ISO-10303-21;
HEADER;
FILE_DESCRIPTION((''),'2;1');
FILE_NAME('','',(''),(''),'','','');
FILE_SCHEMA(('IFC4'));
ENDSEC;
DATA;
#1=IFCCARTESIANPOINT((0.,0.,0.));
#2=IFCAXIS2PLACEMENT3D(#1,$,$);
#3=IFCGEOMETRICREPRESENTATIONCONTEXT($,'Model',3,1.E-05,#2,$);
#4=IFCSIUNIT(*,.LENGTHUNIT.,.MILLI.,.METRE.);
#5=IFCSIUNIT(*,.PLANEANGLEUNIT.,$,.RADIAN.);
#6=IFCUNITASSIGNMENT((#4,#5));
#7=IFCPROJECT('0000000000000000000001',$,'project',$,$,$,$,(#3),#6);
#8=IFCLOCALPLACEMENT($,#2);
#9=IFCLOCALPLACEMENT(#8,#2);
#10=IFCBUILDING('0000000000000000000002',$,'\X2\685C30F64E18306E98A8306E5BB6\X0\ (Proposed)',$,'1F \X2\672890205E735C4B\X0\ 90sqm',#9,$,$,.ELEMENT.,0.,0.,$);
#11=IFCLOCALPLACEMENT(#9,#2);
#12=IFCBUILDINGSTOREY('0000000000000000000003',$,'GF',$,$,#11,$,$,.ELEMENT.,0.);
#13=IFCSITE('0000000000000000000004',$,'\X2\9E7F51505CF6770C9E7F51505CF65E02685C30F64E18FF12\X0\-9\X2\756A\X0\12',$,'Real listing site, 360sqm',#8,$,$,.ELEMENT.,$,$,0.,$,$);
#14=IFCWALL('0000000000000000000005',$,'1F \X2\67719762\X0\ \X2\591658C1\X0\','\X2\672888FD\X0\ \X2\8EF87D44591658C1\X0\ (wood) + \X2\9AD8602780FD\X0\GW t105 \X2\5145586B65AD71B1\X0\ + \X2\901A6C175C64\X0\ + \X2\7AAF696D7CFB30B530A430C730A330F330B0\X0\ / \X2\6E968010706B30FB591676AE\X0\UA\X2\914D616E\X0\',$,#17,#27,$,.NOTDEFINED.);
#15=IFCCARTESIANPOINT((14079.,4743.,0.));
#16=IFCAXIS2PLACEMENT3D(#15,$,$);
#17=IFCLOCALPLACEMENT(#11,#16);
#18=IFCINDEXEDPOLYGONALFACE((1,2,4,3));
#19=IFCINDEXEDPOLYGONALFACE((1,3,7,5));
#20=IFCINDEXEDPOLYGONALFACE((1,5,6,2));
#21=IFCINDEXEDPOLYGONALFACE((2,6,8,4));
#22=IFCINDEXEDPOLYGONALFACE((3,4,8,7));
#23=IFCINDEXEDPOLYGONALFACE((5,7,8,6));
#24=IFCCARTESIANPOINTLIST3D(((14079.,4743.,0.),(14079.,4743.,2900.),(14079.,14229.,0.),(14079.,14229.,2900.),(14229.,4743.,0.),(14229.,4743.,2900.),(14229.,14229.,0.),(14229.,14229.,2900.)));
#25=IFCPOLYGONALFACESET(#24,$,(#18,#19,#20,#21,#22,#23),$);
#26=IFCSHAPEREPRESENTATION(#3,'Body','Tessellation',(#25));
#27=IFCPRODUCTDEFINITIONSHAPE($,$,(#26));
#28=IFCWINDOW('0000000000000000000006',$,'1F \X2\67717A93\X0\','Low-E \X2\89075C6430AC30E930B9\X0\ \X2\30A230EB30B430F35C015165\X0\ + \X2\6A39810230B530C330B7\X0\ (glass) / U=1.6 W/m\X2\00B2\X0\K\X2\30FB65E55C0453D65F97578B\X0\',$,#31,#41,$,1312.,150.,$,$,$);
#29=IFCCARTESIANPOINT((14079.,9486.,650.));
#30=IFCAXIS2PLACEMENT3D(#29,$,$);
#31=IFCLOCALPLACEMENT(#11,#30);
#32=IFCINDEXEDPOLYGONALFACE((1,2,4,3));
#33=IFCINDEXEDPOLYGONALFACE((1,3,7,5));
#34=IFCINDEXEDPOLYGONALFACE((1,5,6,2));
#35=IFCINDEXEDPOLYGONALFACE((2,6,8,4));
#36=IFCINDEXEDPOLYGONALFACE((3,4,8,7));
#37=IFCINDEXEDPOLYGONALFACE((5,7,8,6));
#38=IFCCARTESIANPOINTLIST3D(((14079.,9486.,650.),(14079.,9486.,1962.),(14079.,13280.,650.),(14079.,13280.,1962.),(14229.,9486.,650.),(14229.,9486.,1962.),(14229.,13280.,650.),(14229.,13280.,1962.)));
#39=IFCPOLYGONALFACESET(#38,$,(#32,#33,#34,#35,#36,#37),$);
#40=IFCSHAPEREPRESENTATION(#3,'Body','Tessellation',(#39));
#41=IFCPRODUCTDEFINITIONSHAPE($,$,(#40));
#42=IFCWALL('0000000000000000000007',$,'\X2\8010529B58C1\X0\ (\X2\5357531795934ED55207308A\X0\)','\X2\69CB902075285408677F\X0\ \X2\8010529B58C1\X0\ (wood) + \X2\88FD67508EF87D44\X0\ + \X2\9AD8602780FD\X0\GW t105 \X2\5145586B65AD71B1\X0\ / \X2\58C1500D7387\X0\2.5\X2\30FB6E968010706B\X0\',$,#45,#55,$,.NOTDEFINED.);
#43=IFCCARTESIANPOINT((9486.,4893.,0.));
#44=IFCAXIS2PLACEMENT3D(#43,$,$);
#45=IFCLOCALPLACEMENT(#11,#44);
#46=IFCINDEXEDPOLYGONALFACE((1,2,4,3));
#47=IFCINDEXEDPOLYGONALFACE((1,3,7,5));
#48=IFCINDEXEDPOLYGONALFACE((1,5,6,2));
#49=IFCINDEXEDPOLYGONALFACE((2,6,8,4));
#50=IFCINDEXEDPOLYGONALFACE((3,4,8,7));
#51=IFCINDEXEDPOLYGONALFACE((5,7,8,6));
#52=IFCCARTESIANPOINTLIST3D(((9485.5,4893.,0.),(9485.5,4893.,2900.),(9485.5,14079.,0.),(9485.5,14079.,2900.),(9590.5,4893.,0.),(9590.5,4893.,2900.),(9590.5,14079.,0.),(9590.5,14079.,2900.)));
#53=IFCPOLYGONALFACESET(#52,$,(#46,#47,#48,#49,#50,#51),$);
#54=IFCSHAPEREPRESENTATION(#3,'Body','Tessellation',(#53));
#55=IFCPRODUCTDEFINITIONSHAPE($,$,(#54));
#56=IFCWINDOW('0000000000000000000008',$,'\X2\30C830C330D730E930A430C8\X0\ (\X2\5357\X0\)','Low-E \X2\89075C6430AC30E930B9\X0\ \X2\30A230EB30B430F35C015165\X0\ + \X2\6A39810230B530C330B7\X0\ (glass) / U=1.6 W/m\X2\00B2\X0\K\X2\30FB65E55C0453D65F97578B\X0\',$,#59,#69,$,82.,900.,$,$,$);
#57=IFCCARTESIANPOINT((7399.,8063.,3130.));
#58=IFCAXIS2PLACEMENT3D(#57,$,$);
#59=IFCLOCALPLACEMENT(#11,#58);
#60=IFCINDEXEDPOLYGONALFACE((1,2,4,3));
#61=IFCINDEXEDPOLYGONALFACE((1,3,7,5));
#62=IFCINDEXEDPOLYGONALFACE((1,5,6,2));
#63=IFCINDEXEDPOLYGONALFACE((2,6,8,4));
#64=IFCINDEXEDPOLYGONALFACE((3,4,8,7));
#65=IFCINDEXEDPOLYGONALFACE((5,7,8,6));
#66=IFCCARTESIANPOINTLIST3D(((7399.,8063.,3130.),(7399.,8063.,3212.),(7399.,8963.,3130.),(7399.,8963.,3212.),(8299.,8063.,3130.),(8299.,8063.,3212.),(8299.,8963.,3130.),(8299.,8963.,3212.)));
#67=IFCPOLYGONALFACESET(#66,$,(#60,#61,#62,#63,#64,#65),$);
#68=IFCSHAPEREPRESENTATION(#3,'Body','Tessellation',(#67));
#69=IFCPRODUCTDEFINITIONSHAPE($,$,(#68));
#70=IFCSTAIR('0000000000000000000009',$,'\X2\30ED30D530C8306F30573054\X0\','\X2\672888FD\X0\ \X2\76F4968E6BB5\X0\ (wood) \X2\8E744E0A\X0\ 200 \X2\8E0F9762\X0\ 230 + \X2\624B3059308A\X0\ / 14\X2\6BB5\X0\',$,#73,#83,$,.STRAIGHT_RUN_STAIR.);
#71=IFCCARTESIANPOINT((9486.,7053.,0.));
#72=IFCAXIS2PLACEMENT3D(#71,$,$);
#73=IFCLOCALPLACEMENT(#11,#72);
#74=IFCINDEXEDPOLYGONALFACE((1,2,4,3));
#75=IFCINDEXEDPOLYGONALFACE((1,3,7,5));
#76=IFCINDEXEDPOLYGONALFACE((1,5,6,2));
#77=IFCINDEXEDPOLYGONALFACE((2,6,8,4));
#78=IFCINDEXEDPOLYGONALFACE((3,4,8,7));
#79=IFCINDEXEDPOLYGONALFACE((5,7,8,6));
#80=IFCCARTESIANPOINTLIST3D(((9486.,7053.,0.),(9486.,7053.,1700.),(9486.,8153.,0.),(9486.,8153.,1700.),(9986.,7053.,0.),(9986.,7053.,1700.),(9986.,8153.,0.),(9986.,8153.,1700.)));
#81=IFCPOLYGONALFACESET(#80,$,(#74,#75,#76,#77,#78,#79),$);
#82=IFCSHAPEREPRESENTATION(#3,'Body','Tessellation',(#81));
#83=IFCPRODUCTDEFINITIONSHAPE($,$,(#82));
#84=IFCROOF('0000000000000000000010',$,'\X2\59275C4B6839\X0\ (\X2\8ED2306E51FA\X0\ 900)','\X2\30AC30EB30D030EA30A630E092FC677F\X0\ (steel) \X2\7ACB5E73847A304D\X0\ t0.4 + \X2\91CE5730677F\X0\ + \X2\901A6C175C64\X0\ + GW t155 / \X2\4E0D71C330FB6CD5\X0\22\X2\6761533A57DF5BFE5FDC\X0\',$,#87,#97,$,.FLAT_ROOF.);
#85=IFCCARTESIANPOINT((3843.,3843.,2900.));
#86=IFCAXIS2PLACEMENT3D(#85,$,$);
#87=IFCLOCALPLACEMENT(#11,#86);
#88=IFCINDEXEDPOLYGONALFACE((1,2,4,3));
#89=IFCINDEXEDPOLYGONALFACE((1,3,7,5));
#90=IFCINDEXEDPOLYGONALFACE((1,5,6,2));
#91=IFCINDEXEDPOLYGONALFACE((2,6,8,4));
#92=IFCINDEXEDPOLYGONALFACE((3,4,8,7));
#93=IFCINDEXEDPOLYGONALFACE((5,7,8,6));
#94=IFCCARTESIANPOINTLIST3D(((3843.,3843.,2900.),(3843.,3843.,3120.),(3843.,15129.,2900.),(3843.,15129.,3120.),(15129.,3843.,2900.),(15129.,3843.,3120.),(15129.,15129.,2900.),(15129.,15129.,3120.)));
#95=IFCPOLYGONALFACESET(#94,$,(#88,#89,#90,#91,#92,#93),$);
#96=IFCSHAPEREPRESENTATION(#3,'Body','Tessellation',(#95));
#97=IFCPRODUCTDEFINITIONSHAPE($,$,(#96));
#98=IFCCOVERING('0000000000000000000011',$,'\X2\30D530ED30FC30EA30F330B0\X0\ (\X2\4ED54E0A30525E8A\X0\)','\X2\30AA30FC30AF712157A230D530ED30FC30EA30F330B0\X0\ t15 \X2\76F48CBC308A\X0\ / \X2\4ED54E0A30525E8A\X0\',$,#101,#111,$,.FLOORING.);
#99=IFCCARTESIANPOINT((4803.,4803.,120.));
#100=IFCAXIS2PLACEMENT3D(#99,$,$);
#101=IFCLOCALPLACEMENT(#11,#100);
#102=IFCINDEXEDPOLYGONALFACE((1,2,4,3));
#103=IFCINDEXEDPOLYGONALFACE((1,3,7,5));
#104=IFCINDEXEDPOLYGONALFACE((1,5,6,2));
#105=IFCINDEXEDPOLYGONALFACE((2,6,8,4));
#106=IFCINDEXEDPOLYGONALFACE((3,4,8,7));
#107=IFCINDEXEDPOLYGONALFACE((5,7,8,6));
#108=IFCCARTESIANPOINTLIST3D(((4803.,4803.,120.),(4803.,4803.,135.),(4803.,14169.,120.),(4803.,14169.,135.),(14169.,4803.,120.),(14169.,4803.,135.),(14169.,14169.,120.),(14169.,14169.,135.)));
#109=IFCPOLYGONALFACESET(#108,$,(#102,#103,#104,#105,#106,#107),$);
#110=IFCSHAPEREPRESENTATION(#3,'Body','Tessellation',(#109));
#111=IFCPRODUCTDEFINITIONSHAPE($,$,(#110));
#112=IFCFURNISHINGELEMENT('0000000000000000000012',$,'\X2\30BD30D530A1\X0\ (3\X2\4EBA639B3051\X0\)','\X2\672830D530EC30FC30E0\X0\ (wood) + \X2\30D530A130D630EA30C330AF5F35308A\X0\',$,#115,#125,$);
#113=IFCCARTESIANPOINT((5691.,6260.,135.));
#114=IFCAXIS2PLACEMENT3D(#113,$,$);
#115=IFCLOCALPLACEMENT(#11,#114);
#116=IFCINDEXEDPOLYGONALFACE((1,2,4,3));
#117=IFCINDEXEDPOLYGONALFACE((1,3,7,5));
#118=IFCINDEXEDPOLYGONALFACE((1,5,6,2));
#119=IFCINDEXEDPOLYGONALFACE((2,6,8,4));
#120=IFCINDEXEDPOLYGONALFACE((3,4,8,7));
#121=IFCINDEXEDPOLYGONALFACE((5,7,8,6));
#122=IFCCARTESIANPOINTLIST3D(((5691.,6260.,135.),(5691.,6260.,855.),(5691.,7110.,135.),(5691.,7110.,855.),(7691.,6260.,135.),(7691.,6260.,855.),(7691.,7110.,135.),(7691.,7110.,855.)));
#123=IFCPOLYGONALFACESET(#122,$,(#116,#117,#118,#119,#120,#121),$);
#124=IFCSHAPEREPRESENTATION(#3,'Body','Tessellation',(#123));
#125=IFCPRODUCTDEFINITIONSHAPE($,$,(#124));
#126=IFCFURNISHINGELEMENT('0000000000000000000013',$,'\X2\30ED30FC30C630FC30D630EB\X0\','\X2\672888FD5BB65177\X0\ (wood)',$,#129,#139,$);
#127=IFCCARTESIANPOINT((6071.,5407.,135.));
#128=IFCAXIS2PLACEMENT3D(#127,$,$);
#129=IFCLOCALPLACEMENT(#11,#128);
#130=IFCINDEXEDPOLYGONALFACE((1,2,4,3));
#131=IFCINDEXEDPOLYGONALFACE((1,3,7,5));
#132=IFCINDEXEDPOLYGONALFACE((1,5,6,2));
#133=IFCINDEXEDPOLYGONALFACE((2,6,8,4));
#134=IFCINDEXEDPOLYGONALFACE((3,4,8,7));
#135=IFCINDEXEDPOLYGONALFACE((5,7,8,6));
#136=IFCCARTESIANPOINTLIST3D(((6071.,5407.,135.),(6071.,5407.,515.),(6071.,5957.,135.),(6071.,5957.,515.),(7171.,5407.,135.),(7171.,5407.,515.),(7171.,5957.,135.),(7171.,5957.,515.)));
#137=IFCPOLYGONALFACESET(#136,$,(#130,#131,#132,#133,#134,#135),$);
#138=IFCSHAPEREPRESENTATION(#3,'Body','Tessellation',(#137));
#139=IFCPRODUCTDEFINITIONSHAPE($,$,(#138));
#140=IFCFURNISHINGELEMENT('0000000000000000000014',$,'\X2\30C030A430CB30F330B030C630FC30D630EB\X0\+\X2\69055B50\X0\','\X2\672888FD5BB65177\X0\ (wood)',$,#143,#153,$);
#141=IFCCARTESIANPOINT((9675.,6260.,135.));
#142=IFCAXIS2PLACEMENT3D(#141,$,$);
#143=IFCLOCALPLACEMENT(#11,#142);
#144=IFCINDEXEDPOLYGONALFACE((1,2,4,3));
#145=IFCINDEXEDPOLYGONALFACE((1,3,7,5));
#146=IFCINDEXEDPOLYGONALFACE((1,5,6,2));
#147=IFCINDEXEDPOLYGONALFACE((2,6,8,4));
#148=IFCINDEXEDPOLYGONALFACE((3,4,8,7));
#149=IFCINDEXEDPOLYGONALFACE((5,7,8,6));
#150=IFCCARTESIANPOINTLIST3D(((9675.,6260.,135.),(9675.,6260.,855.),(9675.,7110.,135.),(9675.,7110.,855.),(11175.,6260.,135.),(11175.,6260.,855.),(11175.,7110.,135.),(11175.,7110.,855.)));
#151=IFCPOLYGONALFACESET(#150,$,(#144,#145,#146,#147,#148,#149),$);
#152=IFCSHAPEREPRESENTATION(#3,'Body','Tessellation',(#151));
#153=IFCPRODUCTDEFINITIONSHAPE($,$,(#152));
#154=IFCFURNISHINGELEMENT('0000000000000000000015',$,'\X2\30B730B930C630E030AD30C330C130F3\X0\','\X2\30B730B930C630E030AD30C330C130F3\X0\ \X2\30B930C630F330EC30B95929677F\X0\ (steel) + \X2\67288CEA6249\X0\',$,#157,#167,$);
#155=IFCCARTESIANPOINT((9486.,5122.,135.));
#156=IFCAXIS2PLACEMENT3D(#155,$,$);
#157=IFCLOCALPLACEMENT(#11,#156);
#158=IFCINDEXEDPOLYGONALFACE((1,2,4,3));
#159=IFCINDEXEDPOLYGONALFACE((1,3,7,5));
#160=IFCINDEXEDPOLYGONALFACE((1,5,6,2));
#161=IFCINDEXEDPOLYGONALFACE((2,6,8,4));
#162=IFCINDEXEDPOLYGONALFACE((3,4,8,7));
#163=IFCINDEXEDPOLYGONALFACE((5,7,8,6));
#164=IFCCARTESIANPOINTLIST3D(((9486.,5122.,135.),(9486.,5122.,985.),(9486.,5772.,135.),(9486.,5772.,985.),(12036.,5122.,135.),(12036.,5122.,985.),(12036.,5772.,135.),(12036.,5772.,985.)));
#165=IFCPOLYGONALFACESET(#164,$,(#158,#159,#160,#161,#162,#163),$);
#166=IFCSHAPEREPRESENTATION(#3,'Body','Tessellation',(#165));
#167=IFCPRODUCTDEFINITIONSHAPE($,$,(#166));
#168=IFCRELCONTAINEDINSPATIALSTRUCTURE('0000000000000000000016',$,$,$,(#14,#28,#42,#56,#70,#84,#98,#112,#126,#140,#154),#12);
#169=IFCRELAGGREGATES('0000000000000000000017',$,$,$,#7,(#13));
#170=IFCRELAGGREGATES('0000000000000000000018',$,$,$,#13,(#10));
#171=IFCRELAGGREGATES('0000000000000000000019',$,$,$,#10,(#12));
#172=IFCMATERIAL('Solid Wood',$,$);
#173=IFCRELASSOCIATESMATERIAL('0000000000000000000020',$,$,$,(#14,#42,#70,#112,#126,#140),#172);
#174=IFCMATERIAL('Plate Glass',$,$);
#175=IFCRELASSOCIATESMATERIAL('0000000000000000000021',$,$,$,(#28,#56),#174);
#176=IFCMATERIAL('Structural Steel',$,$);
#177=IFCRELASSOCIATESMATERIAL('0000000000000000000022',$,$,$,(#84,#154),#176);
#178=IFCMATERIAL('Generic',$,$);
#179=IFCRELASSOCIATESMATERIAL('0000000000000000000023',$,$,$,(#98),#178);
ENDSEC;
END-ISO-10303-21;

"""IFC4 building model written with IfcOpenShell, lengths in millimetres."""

from ifc_helpers import new_model, si_unit, frame, frame_2d, origin, place, context, project, spatial, rectangle, extrude, material, element, fill, save


model = new_model("IFC4")

# Units and contexts
model_context = context("Model", 3, precision=1e-05, world=origin())
ifc_project = project(units=[si_unit("LENGTHUNIT", "METRE", prefix="MILLI"), si_unit("PLANEANGLEUNIT", "RADIAN")], contexts=[model_context])

# Site, building, storey
site_placement = place(None, origin())
site = spatial("IfcSite", under=ifc_project, at=site_placement, Name="鹿児島県鹿児島市桜ヶ丘２-9番12", ObjectType="Real listing site, 360sqm", CompositionType="ELEMENT", RefElevation=0.0)
building_placement = place(site_placement, origin())
building = spatial("IfcBuilding", under=site, at=building_placement, Name="桜ヶ丘の風の家 (Proposed)", ObjectType="1F 木造平屋 90sqm", CompositionType="ELEMENT", ElevationOfRefHeight=0.0, ElevationOfTerrain=0.0)
storey_placement = place(building_placement, origin())
storey = spatial("IfcBuildingStorey", under=building, at=storey_placement, Name="GF", CompositionType="ELEMENT", Elevation=0.0)

# Shared definitions
ifc_material_1 = material(Name="Solid Wood")

# Shared definitions
ifc_material_2 = material(Name="Plate Glass")

# Wall, opening, window
wall_1_placement = place(storey_placement, frame((14079.0, 4743.0, 0.0)))
wall_1 = element("IfcWall", 1, at=wall_1_placement, inside=storey, material=ifc_material_1, Name="1F 東面 外壁", Description="木製 軸組外壁 (wood) + 高性能GW t105 充填断熱 + 通気層 + 窯業系サイディング / 準耐火・外皮UA配慮", PredefinedType="NOTDEFINED", context=model_context, shape_type="SweptSolid", body=[
    extrude(rectangle(XDim=150.0, YDim=9486.0, at=frame_2d((75.0, 4743.0))), frame((14079.0, 4743.0, 0.0)), (0.0, 0.0, 1.0), 2900.0),
])
opening_1_placement = place(storey_placement, frame((14079.0, 9486.0, 650.0)))
opening_1 = element("IfcOpeningElement", 2, at=opening_1_placement, cuts=wall_1, PredefinedType="NOTDEFINED", context=model_context, shape_type="SweptSolid", body=[
    extrude(rectangle(XDim=150.0, YDim=3794.0, at=frame_2d((75.0, 1897.0))), frame((14079.0, 9486.0, 650.0)), (0.0, 0.0, 1.0), 1312.0),
])
window_1_placement = place(storey_placement, frame((14079.0, 9486.0, 650.0)))
window_1 = element("IfcWindow", 3, at=window_1_placement, inside=storey, material=ifc_material_2, Name="1F 東窓", Description="Low-E 複層ガラス アルゴン封入 + 樹脂サッシ (glass) / U=1.6 W/m²K・日射取得型", OverallHeight=1312.0, OverallWidth=150.0, context=model_context, shape_type="SweptSolid", body=[
    extrude(rectangle(XDim=150.0, YDim=3794.0, at=frame_2d((75.0, 1897.0))), frame((14079.0, 9486.0, 650.0)), (0.0, 0.0, 1.0), 1312.0),
])
fill(opening_1, window_1)

# Wall
wall_2_placement = place(storey_placement, frame((9486.0, 4893.0, 0.0)))
element("IfcWall", 4, at=wall_2_placement, inside=storey, material=ifc_material_1, Name="耐力壁 (南北間仕切り)", Description="構造用合板 耐力壁 (wood) + 製材軸組 + 高性能GW t105 充填断熱 / 壁倍率2.5・準耐火", PredefinedType="NOTDEFINED", context=model_context, shape_type="SweptSolid", body=[
    extrude(rectangle(XDim=105.0, YDim=9186.0, at=frame_2d((52.0, 4593.0))), frame((9486.0, 4893.0, 0.0)), (0.0, 0.0, 1.0), 2900.0),
])

# Window
window_2_placement = place(storey_placement, frame((7399.0, 8063.0, 3130.0)))
element("IfcWindow", 5, at=window_2_placement, inside=storey, material=ifc_material_2, Name="トップライト (南)", Description="Low-E 複層ガラス アルゴン封入 + 樹脂サッシ (glass) / U=1.6 W/m²K・日射取得型", OverallHeight=82.0, OverallWidth=900.0, context=model_context, shape_type="SweptSolid", body=[
    extrude(rectangle(XDim=900.0, YDim=900.0, at=frame_2d((450.0, 450.0))), frame((7399.0, 8063.0, 3130.0)), (0.0, 0.0, 1.0), 82.0),
])

# Stair
stair_placement = place(storey_placement, frame((9486.0, 7053.0, 0.0)))
element("IfcStair", 6, at=stair_placement, inside=storey, material=ifc_material_1, Name="ロフトはしご", Description="木製 直階段 (wood) 蹴上 200 踏面 230 + 手すり / 14段", PredefinedType="STRAIGHT_RUN_STAIR", context=model_context, shape_type="SweptSolid", body=[
    extrude(rectangle(XDim=500.0, YDim=1100.0, at=frame_2d((250.0, 550.0))), frame((9486.0, 7053.0, 0.0)), (0.0, 0.0, 1.0), 1700.0),
])

# Roof
ifc_material_3 = material(Name="Structural Steel")
roof_placement = place(storey_placement, frame((3843.0, 3843.0, 2900.0)))
element("IfcRoof", 7, at=roof_placement, inside=storey, material=ifc_material_3, Name="大屋根 (軒の出 900)", Description="ガルバリウム鋼板 (steel) 立平葺き t0.4 + 野地板 + 通気層 + GW t155 / 不燃・法22条区域対応", PredefinedType="FLAT_ROOF", context=model_context, shape_type="SweptSolid", body=[
    extrude(rectangle(XDim=11286.0, YDim=11286.0, at=frame_2d((5643.0, 5643.0))), frame((3843.0, 3843.0, 2900.0)), (0.0, 0.0, 1.0), 220.0),
])

# Covering
ifc_material_4 = material(Name="Generic")
covering_placement = place(storey_placement, frame((4803.0, 4803.0, 120.0)))
element("IfcCovering", 8, at=covering_placement, inside=storey, material=ifc_material_4, Name="フローリング (仕上げ床)", Description="オーク無垢フローリング t15 直貼り / 仕上げ床", PredefinedType="FLOORING", context=model_context, shape_type="SweptSolid", body=[
    extrude(rectangle(XDim=9366.0, YDim=9366.0, at=frame_2d((4683.0, 4683.0))), frame((4803.0, 4803.0, 120.0)), (0.0, 0.0, 1.0), 15.0),
])

# Furnishing elements
furnishing_1_placement = place(storey_placement, frame((5691.0, 6260.0, 135.0)))
element("IfcFurnishingElement", 9, at=furnishing_1_placement, inside=storey, material=ifc_material_1, Name="ソファ (3人掛け)", Description="木フレーム (wood) + ファブリック張り", context=model_context, shape_type="SweptSolid", body=[
    extrude(rectangle(XDim=2000.0, YDim=850.0, at=frame_2d((1000.0, 425.0))), frame((5691.0, 6260.0, 135.0)), (0.0, 0.0, 1.0), 720.0),
])
furnishing_2_placement = place(storey_placement, frame((6071.0, 5407.0, 135.0)))
element("IfcFurnishingElement", 10, at=furnishing_2_placement, inside=storey, material=ifc_material_1, Name="ローテーブル", Description="木製家具 (wood)", context=model_context, shape_type="SweptSolid", body=[
    extrude(rectangle(XDim=1100.0, YDim=550.0, at=frame_2d((550.0, 275.0))), frame((6071.0, 5407.0, 135.0)), (0.0, 0.0, 1.0), 380.0),
])
furnishing_3_placement = place(storey_placement, frame((9675.0, 6260.0, 135.0)))
element("IfcFurnishingElement", 11, at=furnishing_3_placement, inside=storey, material=ifc_material_1, Name="ダイニングテーブル+椅子", Description="木製家具 (wood)", context=model_context, shape_type="SweptSolid", body=[
    extrude(rectangle(XDim=1500.0, YDim=850.0, at=frame_2d((750.0, 425.0))), frame((9675.0, 6260.0, 135.0)), (0.0, 0.0, 1.0), 720.0),
])
furnishing_4_placement = place(storey_placement, frame((9486.0, 5122.0, 135.0)))
element("IfcFurnishingElement", 12, at=furnishing_4_placement, inside=storey, material=ifc_material_3, Name="システムキッチン", Description="システムキッチン ステンレス天板 (steel) + 木質扉", context=model_context, shape_type="SweptSolid", body=[
    extrude(rectangle(XDim=2550.0, YDim=650.0, at=frame_2d((1275.0, 325.0))), frame((9486.0, 5122.0, 135.0)), (0.0, 0.0, 1.0), 850.0),
])

save(model, "model.ifc")
